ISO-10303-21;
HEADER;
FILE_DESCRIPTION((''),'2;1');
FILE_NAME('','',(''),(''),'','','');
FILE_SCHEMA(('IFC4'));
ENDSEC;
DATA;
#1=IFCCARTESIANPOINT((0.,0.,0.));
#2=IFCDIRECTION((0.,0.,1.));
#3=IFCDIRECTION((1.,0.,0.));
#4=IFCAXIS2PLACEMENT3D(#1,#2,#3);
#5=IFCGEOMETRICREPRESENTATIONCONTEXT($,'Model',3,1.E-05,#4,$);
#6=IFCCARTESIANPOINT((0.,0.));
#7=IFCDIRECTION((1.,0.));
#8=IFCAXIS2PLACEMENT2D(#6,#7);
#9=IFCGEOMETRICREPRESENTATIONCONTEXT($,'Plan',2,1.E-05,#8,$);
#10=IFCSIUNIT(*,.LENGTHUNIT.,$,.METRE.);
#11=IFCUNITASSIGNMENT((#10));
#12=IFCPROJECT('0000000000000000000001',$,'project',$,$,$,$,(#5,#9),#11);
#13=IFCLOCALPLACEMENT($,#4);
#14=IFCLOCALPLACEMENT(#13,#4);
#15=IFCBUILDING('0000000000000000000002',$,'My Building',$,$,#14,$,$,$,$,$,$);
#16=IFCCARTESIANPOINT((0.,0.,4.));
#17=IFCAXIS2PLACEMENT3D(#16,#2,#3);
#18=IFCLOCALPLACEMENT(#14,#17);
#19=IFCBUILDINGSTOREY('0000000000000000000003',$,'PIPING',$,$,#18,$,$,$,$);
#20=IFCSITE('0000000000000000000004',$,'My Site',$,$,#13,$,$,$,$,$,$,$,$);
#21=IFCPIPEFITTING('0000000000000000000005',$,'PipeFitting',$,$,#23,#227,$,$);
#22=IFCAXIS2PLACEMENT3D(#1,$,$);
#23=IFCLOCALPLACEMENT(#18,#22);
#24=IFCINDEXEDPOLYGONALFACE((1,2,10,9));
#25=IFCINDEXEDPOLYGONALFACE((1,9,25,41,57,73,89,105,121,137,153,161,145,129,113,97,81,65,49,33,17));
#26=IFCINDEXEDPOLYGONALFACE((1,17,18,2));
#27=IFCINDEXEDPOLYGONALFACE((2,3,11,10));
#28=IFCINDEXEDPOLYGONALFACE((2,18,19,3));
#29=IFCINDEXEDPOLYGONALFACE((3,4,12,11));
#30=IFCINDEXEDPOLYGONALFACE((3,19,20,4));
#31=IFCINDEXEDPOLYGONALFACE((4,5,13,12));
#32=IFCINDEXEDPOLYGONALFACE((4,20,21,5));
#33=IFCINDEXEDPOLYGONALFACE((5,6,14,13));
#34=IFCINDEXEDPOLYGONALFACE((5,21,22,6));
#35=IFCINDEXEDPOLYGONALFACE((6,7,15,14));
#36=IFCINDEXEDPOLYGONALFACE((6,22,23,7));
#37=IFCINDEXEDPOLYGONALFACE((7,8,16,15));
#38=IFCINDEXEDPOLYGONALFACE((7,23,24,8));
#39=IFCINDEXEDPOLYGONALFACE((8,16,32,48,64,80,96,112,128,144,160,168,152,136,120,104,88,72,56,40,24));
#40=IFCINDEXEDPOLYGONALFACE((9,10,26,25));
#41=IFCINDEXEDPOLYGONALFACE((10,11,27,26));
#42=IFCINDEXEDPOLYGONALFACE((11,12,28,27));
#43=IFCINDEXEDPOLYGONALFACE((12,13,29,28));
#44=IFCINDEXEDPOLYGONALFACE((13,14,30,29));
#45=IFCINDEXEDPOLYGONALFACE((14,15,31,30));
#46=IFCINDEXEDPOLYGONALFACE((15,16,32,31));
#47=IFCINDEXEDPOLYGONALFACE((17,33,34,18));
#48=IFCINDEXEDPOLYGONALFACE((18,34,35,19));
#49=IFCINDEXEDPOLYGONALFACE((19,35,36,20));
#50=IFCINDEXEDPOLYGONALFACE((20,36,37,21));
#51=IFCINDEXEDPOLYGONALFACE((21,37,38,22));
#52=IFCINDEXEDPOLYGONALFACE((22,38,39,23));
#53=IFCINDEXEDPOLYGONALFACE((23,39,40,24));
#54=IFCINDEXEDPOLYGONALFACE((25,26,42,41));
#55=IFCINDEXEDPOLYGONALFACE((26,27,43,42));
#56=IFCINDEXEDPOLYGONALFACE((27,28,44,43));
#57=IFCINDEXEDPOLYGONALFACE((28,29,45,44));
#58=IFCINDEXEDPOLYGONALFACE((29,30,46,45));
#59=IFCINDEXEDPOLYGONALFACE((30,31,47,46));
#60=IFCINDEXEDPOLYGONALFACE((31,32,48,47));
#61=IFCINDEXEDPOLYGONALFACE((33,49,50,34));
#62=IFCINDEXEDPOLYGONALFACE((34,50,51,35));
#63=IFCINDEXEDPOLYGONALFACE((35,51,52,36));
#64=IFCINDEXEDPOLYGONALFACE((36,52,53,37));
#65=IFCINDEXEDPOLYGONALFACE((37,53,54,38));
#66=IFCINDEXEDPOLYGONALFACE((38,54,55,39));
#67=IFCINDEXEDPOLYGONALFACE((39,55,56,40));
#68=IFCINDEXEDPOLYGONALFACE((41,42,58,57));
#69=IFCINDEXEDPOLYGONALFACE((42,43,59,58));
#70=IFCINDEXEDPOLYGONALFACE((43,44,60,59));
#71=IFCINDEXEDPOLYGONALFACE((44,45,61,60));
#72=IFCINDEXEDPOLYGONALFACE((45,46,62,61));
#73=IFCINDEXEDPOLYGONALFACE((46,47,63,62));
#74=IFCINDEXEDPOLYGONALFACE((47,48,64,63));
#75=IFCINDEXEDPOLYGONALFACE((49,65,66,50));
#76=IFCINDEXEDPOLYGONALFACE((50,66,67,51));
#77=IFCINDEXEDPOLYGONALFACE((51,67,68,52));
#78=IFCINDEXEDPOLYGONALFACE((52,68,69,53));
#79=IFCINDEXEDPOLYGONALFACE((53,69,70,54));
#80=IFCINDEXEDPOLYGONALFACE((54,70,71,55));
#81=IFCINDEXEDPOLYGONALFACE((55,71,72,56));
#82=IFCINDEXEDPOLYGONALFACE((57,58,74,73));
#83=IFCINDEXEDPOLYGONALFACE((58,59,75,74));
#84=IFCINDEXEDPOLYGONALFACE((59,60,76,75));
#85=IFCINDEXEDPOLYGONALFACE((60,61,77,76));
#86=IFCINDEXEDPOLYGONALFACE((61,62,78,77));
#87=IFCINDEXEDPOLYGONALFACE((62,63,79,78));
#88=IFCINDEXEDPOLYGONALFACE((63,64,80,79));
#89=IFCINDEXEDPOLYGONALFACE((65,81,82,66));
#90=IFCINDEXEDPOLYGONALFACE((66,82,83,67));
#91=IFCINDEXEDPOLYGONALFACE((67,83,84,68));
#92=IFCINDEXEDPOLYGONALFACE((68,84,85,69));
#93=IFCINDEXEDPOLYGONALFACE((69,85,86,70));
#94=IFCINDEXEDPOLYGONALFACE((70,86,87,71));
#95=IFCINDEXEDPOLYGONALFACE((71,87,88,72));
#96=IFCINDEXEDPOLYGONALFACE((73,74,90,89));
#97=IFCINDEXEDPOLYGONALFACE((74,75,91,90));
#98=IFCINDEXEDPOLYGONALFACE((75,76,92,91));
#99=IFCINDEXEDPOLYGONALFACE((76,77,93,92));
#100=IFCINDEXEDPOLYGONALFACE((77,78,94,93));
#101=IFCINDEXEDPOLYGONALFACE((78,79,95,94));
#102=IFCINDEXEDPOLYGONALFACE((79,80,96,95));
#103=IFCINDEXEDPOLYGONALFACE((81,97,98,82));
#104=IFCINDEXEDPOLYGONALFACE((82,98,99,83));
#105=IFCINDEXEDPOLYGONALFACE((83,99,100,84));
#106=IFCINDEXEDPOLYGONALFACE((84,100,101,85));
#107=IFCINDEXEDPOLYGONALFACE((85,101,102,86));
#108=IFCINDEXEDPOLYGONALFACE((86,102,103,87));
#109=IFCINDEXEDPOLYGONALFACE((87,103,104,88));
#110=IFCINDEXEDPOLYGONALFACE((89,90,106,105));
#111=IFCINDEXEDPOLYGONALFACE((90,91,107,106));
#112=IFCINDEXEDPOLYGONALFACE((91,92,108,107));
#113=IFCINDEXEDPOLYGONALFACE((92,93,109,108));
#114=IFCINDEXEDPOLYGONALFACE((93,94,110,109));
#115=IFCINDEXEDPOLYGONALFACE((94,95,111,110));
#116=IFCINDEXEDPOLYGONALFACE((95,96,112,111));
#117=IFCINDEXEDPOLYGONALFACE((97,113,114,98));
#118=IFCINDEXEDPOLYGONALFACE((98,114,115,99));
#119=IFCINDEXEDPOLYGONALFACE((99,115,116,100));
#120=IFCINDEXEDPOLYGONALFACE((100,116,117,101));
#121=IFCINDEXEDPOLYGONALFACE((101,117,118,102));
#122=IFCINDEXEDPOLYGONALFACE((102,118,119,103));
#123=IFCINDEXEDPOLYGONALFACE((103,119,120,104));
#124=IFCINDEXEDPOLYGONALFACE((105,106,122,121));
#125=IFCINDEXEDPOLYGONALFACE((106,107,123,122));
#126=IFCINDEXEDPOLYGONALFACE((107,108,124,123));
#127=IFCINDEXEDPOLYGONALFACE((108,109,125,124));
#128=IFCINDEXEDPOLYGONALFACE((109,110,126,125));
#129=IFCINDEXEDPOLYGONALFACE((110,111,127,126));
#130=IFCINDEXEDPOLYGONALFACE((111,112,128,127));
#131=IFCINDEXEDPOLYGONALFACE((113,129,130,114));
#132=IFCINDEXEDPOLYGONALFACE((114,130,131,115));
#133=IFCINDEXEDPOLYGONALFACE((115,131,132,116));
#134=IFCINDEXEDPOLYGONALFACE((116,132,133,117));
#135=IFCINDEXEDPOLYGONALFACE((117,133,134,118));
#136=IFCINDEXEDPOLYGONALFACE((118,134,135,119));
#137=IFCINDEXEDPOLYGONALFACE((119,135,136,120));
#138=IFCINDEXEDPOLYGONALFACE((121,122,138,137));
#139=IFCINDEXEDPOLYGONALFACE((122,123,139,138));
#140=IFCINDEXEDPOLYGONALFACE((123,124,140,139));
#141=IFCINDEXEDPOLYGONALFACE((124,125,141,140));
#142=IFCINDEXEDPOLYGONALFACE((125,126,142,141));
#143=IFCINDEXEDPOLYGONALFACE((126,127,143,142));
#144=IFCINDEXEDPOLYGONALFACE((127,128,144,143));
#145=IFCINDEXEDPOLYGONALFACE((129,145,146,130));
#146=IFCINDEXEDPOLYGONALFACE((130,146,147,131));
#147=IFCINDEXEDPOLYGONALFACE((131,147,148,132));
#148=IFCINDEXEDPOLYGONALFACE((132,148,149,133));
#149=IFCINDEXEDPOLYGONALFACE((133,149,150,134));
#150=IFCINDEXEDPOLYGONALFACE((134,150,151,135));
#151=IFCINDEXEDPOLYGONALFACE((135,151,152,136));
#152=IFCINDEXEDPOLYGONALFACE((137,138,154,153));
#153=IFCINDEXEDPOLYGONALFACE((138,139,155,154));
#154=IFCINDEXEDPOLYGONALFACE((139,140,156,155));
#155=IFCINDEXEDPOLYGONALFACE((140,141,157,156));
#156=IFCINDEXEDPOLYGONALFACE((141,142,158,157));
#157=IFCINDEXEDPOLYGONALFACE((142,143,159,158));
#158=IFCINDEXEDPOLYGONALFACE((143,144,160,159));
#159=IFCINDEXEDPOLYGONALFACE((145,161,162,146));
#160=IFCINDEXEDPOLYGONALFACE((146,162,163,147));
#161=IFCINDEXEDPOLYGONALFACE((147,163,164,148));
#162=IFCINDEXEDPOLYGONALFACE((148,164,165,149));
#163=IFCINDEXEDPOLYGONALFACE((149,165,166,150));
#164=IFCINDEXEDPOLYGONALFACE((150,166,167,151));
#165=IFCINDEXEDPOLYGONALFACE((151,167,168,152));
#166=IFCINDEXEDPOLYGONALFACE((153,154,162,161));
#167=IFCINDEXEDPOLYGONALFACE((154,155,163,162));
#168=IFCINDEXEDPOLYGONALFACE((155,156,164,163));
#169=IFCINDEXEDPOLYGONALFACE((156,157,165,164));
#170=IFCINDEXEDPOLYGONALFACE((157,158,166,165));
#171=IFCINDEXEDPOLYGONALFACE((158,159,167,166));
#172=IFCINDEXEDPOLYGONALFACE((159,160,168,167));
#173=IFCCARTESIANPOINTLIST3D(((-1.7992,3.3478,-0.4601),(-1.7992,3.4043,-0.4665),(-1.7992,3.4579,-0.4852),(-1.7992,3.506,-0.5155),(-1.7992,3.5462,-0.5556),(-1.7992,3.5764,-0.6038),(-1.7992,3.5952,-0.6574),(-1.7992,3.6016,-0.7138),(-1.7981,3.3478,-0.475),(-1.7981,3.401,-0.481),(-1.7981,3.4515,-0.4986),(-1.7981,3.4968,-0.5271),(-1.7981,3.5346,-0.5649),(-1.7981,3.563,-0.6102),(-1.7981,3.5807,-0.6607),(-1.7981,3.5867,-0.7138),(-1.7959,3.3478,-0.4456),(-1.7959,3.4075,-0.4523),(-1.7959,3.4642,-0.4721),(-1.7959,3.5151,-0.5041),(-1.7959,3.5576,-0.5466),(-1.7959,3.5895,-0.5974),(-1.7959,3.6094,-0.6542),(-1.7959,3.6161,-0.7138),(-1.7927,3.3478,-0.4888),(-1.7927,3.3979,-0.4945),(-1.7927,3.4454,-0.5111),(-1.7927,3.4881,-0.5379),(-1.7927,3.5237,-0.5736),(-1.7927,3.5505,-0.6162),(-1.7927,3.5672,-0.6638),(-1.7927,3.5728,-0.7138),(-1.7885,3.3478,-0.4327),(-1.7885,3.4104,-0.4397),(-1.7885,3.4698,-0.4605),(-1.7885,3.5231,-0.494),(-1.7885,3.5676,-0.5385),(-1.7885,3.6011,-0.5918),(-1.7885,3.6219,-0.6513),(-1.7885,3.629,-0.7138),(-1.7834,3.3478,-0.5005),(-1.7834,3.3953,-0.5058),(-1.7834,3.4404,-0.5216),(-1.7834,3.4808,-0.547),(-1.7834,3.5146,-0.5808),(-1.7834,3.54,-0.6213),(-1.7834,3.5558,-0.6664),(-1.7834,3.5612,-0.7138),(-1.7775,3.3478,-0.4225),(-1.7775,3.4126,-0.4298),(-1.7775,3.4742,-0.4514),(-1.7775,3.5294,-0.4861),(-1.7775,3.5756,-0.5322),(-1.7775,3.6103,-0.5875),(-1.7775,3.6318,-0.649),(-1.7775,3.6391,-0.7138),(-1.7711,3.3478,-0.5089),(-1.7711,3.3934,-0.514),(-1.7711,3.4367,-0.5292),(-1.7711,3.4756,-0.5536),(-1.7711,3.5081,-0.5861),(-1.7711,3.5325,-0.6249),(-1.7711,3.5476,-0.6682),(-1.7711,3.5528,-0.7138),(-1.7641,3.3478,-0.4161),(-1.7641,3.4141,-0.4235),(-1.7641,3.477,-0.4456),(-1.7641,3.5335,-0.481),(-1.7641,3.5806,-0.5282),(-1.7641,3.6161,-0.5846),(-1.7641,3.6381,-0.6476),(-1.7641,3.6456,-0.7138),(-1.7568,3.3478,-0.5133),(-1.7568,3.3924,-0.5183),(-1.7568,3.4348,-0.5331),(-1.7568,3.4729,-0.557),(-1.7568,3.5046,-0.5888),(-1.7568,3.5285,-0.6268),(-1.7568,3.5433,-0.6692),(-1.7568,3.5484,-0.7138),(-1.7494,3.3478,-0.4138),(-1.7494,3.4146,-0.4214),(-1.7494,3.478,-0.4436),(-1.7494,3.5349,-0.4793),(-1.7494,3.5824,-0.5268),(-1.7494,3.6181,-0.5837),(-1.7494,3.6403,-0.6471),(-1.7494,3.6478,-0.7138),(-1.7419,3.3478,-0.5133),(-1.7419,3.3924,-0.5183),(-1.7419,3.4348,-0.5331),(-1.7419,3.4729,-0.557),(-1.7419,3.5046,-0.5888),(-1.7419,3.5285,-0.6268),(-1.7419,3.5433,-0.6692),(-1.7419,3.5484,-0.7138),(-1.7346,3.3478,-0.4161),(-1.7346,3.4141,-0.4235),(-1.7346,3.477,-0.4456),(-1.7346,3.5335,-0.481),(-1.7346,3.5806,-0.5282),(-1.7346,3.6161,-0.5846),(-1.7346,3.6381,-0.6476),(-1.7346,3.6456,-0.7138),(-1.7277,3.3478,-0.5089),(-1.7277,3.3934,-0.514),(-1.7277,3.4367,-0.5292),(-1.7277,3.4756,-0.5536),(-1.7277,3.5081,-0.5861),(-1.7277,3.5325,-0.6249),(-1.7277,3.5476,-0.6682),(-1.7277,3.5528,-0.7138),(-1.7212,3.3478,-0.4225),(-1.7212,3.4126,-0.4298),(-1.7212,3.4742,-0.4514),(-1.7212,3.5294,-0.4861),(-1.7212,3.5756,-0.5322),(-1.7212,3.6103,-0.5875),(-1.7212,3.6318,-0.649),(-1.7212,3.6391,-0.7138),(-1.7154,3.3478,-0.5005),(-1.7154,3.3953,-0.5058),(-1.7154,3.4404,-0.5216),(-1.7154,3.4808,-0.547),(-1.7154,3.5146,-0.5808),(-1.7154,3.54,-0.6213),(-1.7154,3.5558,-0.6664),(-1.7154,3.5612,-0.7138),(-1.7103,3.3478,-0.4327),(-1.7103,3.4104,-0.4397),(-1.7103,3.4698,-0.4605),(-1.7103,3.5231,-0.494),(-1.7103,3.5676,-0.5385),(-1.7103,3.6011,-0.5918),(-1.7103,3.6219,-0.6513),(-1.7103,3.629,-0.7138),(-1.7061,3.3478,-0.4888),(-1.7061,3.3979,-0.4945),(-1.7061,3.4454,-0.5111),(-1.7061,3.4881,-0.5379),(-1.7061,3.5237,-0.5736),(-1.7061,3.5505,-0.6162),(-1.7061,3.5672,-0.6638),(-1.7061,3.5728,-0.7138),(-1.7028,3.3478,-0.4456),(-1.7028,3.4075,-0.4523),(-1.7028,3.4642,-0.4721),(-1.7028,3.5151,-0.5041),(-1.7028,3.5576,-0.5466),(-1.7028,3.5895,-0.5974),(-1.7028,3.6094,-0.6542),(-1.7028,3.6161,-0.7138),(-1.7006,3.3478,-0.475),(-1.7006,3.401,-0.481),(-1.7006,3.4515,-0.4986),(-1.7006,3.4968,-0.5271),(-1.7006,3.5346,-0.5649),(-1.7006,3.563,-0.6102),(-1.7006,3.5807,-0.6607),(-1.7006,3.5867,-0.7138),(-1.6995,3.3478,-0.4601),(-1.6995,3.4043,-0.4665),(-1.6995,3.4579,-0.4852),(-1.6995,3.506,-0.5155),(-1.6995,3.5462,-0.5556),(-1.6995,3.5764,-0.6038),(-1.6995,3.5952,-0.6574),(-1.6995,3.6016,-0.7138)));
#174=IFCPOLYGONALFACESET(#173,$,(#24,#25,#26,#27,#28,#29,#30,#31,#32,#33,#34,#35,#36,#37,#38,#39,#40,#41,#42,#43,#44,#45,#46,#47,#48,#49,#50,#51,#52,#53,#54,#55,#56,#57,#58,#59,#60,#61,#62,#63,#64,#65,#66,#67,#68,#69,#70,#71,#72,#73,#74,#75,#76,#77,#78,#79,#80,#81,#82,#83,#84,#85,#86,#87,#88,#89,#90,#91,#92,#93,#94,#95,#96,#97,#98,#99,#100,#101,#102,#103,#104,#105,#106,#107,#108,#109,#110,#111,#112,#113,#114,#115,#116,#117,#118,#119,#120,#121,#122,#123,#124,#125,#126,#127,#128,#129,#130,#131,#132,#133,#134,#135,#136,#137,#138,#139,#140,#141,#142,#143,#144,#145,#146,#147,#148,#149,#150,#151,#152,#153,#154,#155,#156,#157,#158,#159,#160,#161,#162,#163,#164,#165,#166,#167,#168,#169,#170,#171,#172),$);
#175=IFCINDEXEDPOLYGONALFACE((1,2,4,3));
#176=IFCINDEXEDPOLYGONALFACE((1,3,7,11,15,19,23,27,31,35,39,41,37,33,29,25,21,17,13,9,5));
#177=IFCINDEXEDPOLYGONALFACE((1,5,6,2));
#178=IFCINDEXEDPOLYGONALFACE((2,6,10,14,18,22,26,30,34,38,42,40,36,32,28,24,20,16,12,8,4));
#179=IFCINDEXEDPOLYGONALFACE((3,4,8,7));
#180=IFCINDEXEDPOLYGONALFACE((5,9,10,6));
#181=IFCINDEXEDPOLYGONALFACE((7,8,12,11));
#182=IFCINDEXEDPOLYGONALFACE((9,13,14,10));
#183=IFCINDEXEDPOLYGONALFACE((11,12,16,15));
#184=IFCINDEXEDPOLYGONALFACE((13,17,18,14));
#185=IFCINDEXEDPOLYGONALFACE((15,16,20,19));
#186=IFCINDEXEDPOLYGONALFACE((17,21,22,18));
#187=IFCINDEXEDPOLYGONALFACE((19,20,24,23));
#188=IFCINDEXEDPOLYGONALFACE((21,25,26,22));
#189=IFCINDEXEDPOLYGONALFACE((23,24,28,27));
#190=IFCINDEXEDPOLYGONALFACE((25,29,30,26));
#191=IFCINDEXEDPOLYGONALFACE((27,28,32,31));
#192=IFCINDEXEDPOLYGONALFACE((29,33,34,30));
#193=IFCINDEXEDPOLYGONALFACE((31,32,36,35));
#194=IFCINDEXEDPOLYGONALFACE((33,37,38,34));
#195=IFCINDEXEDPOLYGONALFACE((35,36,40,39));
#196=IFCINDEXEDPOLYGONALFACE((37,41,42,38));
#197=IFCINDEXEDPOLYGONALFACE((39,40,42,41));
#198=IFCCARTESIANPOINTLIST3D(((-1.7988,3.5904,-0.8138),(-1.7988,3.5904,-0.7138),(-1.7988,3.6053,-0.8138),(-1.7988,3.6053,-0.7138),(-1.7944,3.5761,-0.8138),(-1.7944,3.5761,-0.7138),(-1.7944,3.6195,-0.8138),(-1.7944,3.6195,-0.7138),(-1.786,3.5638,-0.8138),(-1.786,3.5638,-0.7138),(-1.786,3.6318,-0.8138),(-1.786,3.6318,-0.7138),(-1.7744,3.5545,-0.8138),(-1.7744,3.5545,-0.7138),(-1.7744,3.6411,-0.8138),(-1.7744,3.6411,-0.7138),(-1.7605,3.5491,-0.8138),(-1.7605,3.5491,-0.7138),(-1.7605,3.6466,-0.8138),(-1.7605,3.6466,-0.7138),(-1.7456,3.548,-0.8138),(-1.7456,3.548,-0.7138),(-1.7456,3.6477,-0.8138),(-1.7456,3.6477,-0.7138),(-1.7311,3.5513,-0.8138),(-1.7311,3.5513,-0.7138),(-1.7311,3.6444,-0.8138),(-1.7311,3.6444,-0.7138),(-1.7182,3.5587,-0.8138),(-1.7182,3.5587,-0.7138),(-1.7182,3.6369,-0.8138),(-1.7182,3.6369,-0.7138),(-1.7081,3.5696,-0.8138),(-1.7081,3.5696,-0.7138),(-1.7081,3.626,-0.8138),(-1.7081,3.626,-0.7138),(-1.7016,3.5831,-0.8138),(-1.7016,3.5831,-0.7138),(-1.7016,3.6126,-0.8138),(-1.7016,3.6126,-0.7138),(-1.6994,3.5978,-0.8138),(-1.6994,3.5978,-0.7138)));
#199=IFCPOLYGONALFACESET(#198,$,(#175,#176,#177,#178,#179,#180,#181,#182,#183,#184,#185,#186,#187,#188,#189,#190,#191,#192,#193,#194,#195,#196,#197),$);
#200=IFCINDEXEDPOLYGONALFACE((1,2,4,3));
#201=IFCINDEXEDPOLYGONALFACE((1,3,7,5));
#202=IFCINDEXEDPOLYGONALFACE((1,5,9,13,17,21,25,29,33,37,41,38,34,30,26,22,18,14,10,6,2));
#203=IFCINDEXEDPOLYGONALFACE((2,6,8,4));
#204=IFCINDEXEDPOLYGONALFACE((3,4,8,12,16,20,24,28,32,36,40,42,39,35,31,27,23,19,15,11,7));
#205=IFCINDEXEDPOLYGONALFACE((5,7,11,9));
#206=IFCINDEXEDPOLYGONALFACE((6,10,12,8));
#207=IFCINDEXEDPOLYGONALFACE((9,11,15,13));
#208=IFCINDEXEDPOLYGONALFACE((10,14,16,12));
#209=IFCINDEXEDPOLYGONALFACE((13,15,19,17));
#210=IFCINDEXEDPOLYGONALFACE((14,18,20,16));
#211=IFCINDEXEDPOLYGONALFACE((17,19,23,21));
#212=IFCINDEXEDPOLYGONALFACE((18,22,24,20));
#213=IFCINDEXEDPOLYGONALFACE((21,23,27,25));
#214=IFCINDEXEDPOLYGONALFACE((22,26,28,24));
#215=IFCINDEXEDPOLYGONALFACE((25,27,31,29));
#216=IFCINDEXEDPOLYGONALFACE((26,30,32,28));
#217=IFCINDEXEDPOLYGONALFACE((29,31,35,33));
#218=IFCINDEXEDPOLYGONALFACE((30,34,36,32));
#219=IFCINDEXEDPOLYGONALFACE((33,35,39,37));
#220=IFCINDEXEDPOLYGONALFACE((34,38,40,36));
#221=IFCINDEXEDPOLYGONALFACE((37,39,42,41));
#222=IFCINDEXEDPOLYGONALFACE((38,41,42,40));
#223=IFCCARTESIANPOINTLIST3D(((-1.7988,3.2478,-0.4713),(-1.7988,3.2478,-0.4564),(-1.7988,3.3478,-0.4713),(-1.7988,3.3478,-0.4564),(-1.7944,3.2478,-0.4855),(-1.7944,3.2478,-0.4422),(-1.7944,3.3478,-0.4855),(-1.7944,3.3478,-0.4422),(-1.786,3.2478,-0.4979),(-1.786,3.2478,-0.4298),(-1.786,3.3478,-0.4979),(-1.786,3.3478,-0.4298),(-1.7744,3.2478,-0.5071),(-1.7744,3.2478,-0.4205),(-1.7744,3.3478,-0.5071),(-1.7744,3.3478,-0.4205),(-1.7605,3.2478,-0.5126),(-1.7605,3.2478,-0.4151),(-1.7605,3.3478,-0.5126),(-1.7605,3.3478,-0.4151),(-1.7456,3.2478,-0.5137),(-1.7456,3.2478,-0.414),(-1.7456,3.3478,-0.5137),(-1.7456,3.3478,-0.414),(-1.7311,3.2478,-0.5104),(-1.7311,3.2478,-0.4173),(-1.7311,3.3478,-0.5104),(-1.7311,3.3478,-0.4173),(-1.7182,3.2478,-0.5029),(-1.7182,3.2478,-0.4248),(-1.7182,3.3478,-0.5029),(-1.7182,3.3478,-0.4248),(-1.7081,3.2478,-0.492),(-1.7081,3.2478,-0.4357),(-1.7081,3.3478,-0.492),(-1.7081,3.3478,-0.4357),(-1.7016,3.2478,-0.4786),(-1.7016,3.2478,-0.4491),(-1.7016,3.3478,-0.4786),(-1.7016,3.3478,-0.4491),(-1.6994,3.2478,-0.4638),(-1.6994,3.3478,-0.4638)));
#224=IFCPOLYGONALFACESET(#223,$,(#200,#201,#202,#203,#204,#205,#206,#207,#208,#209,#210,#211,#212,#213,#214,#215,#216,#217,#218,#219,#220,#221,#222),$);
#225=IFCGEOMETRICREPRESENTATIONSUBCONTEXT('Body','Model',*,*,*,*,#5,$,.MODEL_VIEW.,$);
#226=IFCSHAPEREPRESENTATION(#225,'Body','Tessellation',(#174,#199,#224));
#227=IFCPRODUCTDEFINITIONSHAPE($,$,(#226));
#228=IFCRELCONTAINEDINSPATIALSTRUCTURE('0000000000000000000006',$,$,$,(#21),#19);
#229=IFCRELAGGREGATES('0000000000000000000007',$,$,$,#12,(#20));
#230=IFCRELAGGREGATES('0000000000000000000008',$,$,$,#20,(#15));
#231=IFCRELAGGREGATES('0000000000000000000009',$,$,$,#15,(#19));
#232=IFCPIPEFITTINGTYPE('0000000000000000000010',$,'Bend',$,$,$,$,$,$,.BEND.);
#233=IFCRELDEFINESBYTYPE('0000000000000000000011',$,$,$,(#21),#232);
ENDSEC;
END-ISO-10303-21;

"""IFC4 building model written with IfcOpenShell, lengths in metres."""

from ifc_helpers import new_model, entity, si_unit, frame, origin_with_axes, origin_2d_with_axis, place, context, subcontext, project, spatial, circle, extrude, source, transform, mapped, type_object, type_shapes, element, save


model = new_model("IFC4")

# Units and contexts
model_context = context("Model", 3, precision=1e-05, world=origin_with_axes())
plan_context = context("Plan", 2, precision=1e-05, world=origin_2d_with_axis())
body_context = subcontext(model_context, "Body", "Model", "MODEL_VIEW")
ifc_project = project(units=[si_unit("LENGTHUNIT", "METRE")], contexts=[model_context, plan_context])

# Site, building, storey
site_placement = place(None, origin_with_axes())
site = spatial("IfcSite", under=ifc_project, at=site_placement, Name="My Site")
building_placement = place(site_placement, origin_with_axes())
building = spatial("IfcBuilding", under=site, at=building_placement, Name="My Building")
storey_placement = place(building_placement, frame((0.0, 0.0, 4.0), z_axis=(0.0, 0.0, 1.0), x_axis=(1.0, 0.0, 0.0)))
storey = spatial("IfcBuildingStorey", under=building, at=storey_placement, Name="PIPING")

# Pipe fitting
pipe_fitting_type = type_object("IfcPipeFittingType", Name="Bend", PredefinedType="BEND")
shared_shape = source(origin_with_axes(), body_context, "Body", "SolidModel", [
    entity("IfcSweptDiskSolid", entity("IfcIndexedPolyCurve", entity("IfcCartesianPointList3D", [[0.0, 0.0, 0.1], [0.0, -0.0732, 0.2768], [0.0, -0.25, 0.35]]), [entity("IfcArcIndex", [1, 2, 3])]), 0.05),
    extrude(circle(Radius=0.05), origin_with_axes(), (0.0, 0.0, 1.0), 0.1),
    extrude(circle(Radius=0.05), frame((0.0, -0.25, 0.35), z_axis=(0.0, -1.0, 0.0), x_axis=(1.0, 0.0, 0.0)), (0.0, 0.0, 1.0), 0.1),
])
type_shapes(pipe_fitting_type, [shared_shape])
for number, where, z_axis, x_axis, name in (
    (1, (-1.7494, 3.5978, -0.8138), (0.0, 0.0, 1.0), (1.0, 0.0, 0.0), "PipeFitting"),
):
    element("IfcPipeFitting", number, at=place(storey_placement, frame(where, z_axis=z_axis, x_axis=x_axis)), inside=storey, type_object=pipe_fitting_type, Name=name, context=body_context, shape_type="MappedRepresentation", body=[
        mapped(shared_shape, transform((0.0, 0.0, 0.0), x_axis=(1.0, 0.0, 0.0), y_axis=(0.0, 1.0, 0.0), z_axis=(0.0, 0.0, 1.0), scale=1.0)),
    ])

save(model, "model.ifc")
